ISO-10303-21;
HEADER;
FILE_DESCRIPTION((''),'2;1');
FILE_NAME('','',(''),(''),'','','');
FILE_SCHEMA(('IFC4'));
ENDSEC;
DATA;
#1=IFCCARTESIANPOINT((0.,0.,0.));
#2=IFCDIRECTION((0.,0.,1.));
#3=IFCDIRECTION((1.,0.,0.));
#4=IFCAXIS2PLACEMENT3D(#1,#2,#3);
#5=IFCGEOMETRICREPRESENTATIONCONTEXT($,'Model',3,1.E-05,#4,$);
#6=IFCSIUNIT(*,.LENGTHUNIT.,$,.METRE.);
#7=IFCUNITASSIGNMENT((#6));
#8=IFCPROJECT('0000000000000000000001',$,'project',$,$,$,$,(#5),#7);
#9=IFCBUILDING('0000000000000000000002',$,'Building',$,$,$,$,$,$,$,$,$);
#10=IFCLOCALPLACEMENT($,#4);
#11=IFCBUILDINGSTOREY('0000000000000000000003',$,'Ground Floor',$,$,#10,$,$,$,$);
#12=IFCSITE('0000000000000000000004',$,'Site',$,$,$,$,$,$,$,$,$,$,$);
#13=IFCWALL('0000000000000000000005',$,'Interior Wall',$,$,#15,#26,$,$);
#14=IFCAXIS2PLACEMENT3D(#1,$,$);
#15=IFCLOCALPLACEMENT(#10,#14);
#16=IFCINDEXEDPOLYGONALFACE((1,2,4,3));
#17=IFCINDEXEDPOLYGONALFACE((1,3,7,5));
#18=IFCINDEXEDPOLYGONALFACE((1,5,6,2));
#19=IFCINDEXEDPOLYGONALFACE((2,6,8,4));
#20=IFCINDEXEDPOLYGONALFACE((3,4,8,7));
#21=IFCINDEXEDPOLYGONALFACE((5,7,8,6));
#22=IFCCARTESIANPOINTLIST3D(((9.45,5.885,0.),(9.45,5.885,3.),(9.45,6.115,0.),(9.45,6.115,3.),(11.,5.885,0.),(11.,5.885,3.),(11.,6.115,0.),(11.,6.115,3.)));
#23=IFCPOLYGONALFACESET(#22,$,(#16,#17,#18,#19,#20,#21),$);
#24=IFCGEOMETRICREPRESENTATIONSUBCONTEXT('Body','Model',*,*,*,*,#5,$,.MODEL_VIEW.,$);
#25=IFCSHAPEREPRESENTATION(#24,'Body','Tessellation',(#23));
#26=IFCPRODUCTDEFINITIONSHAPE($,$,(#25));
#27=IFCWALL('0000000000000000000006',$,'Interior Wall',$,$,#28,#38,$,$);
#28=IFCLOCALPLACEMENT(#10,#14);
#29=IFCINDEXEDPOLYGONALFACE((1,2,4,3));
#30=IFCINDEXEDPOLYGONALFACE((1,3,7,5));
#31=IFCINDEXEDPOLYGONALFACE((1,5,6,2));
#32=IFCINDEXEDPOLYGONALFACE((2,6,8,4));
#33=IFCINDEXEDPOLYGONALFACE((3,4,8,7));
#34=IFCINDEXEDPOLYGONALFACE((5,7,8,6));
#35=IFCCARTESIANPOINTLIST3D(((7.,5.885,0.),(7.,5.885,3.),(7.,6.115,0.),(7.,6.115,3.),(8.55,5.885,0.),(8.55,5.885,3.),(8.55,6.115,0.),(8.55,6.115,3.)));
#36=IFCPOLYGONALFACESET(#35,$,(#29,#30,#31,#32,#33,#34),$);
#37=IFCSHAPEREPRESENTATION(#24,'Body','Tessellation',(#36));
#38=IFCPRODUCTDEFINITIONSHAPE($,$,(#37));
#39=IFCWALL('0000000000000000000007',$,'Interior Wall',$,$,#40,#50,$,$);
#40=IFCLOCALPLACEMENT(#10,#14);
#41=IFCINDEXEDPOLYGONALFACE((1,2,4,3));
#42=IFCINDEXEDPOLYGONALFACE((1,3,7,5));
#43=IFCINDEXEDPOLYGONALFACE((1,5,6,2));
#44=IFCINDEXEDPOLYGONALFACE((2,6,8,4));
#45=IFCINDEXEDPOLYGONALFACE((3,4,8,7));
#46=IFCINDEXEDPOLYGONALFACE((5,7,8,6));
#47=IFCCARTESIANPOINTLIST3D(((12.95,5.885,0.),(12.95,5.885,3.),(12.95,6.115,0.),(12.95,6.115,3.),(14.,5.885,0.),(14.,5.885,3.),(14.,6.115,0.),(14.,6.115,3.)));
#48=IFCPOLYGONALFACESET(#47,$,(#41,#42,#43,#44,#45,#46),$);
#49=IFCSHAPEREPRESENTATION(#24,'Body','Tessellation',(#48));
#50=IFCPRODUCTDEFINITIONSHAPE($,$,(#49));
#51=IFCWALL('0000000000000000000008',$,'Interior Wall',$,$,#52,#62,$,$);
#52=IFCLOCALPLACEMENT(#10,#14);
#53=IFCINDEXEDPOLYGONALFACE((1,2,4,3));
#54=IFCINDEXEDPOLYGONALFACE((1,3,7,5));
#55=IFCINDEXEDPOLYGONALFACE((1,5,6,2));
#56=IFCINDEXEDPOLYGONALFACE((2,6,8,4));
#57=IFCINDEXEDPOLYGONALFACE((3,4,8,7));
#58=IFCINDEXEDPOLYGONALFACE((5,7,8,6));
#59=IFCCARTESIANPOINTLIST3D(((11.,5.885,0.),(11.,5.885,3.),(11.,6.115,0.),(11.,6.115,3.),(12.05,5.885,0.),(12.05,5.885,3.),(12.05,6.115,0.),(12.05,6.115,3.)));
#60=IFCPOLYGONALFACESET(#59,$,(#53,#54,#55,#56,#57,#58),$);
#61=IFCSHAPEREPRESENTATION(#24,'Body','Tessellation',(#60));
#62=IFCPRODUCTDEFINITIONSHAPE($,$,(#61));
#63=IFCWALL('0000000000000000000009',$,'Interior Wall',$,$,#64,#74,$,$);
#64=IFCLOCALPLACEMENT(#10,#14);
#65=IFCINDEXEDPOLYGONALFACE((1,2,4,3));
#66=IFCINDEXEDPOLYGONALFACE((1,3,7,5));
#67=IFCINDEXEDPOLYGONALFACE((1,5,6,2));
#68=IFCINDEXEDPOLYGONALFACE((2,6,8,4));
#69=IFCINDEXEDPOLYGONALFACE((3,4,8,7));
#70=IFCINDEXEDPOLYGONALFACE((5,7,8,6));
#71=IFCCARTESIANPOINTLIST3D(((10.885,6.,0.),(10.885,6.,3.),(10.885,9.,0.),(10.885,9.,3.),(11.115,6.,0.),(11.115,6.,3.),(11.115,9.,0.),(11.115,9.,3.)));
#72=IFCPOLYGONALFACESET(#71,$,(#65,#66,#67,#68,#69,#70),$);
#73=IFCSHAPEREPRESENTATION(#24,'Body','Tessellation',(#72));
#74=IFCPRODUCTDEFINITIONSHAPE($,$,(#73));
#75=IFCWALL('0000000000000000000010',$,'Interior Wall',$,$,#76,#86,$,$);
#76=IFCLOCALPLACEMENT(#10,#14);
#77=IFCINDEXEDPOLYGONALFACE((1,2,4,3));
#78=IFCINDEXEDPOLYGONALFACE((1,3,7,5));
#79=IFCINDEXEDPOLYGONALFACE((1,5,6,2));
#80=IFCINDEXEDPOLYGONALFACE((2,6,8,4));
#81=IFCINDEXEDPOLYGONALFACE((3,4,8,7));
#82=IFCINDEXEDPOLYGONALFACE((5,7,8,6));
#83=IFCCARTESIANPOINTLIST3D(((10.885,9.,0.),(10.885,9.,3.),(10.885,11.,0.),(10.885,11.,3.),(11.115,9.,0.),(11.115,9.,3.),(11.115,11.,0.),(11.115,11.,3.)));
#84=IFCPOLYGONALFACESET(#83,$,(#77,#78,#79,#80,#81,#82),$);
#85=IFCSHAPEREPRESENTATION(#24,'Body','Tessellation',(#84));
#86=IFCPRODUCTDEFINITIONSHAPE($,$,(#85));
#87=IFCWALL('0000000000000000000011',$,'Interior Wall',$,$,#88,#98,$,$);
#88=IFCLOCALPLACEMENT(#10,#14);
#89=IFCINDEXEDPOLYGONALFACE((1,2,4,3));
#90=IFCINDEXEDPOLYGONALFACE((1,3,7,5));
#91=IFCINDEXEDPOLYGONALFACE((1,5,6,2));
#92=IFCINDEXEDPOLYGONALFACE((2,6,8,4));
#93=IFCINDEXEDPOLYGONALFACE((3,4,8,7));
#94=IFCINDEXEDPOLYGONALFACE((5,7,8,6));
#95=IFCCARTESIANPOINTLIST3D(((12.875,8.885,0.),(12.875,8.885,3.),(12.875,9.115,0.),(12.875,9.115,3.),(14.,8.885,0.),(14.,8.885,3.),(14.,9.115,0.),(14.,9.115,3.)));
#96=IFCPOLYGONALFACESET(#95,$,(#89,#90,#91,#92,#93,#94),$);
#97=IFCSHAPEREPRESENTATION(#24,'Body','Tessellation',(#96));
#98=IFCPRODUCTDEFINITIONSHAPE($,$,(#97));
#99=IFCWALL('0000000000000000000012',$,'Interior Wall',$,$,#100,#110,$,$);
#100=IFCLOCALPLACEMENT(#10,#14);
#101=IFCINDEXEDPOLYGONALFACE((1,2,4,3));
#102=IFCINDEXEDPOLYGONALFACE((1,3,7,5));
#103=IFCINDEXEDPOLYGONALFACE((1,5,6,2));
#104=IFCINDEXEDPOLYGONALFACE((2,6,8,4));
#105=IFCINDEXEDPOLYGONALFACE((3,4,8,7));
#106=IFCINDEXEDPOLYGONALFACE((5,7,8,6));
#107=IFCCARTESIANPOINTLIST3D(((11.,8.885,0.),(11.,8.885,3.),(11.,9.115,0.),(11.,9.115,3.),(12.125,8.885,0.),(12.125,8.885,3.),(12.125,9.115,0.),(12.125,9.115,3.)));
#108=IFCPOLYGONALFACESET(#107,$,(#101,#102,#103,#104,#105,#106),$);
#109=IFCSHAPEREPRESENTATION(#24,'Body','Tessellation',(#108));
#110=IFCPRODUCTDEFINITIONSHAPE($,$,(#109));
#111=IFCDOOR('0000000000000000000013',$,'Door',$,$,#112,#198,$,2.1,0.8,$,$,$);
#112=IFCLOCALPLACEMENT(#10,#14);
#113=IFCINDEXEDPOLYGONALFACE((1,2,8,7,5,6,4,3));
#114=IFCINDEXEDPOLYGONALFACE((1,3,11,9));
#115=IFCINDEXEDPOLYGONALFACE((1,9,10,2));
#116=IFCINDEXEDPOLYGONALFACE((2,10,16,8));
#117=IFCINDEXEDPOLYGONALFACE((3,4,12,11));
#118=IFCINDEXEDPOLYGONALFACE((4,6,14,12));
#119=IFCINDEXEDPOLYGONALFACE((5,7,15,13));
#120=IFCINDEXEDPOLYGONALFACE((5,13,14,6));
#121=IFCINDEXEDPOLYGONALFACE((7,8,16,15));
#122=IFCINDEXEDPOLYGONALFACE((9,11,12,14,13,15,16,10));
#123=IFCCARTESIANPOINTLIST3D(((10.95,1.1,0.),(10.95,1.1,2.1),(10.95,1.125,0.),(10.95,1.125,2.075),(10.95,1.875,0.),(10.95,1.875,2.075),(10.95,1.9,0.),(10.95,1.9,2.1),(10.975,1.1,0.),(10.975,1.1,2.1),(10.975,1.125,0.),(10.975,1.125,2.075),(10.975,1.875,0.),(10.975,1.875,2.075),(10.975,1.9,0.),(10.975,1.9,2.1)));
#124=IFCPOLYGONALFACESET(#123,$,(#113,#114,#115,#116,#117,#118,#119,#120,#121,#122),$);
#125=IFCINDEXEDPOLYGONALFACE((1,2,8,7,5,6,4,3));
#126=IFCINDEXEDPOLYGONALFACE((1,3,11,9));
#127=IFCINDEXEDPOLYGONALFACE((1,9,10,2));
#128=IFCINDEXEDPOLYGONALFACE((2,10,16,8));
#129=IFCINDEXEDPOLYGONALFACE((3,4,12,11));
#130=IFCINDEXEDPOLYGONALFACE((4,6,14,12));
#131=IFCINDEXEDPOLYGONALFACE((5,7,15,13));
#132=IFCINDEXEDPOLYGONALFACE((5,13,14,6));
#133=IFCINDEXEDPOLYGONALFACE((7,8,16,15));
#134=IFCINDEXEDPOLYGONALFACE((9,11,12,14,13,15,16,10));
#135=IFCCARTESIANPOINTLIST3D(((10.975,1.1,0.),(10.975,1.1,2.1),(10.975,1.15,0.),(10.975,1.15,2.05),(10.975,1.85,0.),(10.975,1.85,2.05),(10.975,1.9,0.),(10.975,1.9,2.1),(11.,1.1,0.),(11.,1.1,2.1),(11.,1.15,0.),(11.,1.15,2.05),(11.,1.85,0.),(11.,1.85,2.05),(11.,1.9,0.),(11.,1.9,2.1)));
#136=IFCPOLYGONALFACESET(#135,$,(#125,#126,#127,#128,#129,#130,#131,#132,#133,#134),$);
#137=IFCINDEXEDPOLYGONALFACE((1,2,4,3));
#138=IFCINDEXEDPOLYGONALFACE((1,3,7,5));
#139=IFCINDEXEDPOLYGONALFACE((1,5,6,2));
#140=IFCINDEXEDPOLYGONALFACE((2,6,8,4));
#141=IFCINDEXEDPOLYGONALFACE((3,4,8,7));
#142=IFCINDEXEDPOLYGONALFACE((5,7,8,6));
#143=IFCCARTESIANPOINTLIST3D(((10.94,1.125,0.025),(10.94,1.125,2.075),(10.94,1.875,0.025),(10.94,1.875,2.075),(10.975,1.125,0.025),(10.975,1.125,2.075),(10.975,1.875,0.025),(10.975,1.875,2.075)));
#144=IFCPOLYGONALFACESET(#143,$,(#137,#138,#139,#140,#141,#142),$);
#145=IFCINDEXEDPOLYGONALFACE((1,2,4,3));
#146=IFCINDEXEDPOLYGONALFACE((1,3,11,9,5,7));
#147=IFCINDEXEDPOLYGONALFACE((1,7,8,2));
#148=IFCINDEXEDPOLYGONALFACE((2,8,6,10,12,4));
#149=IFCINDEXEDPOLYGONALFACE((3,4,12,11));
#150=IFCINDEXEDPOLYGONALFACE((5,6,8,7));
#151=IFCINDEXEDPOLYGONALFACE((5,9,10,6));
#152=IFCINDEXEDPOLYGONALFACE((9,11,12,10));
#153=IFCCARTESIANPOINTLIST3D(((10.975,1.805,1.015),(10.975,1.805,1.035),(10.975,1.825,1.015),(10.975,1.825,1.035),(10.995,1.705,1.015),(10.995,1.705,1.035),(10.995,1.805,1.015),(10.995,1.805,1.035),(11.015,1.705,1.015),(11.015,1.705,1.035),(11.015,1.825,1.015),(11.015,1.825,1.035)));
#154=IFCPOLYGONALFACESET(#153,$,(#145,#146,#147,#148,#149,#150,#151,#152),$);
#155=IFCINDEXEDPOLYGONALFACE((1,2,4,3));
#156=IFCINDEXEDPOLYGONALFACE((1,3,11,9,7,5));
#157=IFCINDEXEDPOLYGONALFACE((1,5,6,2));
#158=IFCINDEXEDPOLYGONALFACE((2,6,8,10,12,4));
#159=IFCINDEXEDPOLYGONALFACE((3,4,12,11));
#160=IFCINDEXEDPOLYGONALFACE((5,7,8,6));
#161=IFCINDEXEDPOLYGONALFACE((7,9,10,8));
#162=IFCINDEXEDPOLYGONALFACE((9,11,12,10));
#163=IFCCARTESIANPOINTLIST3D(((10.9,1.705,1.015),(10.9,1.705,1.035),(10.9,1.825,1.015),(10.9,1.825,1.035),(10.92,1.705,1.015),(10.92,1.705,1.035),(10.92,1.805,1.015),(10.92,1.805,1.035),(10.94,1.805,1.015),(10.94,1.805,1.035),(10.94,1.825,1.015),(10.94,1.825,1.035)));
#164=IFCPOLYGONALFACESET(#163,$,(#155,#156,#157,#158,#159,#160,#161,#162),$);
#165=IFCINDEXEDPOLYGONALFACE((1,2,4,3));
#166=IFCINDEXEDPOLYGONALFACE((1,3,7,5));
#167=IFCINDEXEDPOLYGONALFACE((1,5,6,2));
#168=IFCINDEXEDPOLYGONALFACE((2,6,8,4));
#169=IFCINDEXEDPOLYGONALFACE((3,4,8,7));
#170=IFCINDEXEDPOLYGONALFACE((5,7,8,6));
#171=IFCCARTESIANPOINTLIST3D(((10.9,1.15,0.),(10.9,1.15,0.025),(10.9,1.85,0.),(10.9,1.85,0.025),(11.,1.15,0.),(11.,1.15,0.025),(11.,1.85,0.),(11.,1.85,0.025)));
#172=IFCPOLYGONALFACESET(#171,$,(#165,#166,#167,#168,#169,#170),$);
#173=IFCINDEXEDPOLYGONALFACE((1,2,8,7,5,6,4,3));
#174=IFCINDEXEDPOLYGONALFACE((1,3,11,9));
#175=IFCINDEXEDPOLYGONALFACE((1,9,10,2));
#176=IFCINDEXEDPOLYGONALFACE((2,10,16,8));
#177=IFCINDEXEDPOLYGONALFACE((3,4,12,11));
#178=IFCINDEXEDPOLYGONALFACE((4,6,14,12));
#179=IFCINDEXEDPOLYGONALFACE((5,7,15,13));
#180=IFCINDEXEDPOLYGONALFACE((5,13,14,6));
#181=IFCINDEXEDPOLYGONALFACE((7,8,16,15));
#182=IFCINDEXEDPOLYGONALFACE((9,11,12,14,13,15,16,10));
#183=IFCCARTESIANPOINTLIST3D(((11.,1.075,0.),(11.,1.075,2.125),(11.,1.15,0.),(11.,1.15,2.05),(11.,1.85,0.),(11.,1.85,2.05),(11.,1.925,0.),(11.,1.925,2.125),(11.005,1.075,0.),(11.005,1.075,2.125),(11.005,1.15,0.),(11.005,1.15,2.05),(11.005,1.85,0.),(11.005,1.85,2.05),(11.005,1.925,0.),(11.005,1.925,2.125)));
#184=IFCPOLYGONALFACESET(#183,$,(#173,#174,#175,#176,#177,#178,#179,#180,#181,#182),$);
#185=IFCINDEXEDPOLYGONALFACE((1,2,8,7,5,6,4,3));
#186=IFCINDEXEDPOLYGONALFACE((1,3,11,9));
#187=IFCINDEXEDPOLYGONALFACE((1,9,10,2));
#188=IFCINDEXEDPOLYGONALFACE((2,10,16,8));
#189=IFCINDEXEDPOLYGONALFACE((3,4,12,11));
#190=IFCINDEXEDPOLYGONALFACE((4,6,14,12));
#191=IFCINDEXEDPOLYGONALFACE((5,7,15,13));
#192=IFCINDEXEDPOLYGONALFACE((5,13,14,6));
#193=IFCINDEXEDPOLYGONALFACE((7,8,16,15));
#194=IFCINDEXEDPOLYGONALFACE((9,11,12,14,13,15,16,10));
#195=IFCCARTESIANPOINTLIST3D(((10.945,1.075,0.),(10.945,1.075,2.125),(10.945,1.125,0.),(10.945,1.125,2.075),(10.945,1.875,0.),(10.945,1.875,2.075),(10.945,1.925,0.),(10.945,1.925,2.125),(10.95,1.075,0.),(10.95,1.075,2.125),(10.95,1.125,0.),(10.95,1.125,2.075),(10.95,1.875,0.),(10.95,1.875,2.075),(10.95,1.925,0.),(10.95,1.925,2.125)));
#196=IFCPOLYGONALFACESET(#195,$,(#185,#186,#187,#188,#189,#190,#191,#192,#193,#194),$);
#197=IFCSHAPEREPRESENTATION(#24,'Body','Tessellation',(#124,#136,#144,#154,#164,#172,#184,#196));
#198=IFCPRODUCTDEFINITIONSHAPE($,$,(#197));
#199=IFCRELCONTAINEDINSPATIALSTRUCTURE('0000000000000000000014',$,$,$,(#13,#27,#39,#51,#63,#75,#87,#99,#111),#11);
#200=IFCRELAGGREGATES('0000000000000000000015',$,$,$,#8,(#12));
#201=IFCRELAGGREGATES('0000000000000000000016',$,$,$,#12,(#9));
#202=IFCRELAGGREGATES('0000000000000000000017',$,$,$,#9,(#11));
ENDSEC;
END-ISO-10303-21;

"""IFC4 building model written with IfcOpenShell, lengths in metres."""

from ifc_helpers import new_model, si_unit, frame, origin_with_axes, place, context, subcontext, project, spatial, line, indexed_curve, outline, extrude, element, save


model = new_model("IFC4")

# Units and contexts
model_context = context("Model", 3, precision=1e-05, world=origin_with_axes())
body_context = subcontext(model_context, "Body", "Model", "MODEL_VIEW")
ifc_project = project(units=[si_unit("LENGTHUNIT", "METRE")], contexts=[model_context])

# Site, building, storey
site = spatial("IfcSite", under=ifc_project, Name="Site")
building = spatial("IfcBuilding", under=site, Name="Building")
storey_placement = place(None, origin_with_axes())
storey = spatial("IfcBuildingStorey", under=building, at=storey_placement, Name="Ground Floor")

# Walls
for number, where, z_axis, x_axis, name in (
    (1, (11.0, 6.0, 0.0), (0.0, 0.0, 1.0), (-1.0, 0.0, 0.0), "Interior Wall"),
    (2, (8.55, 6.0, 0.0), (0.0, 0.0, 1.0), (-1.0, 0.0, 0.0), "Interior Wall"),
):
    element("IfcWall", number, at=place(storey_placement, frame(where, z_axis=z_axis, x_axis=x_axis)), inside=storey, Name=name, context=body_context, shape_type="SweptSolid", body=[
        extrude(outline(indexed_curve([(0.0, 0.0), (0.0, 0.23), (1.55, 0.23), (1.55, 0.0), (0.0, 0.0)], self_intersect=False)), frame((0.0, -0.115, 0.0), z_axis=(0.0, 0.0, 1.0), x_axis=(1.0, 0.0, 0.0)), (0.0, 0.0, 1.0), 3.0),
    ])
for number, where, z_axis, x_axis, name in (
    (3, (14.0, 6.0, 0.0), (0.0, 0.0, 1.0), (-1.0, 0.0, 0.0), "Interior Wall"),
    (4, (12.05, 6.0, 0.0), (0.0, 0.0, 1.0), (-1.0, 0.0, 0.0), "Interior Wall"),
):
    element("IfcWall", number, at=place(storey_placement, frame(where, z_axis=z_axis, x_axis=x_axis)), inside=storey, Name=name, context=body_context, shape_type="SweptSolid", body=[
        extrude(outline(indexed_curve([(0.0, 0.0), (0.0, 0.23), (1.05, 0.23), (1.05, 0.0), (0.0, 0.0)], self_intersect=False)), frame((0.0, -0.115, 0.0), z_axis=(0.0, 0.0, 1.0), x_axis=(1.0, 0.0, 0.0)), (0.0, 0.0, 1.0), 3.0),
    ])
wall_1_placement = place(storey_placement, frame((11.0, 6.0, 0.0), z_axis=(0.0, 0.0, 1.0), x_axis=(0.0, 1.0, 0.0)))
element("IfcWall", 5, at=wall_1_placement, inside=storey, Name="Interior Wall", context=body_context, shape_type="SweptSolid", body=[
    extrude(outline(indexed_curve([(0.0, 0.0), (0.0, 0.23), (3.0, 0.23), (3.0, 0.0), (0.0, 0.0)], self_intersect=False)), frame((0.0, -0.115, 0.0), z_axis=(0.0, 0.0, 1.0), x_axis=(1.0, 0.0, 0.0)), (0.0, 0.0, 1.0), 3.0),
])
wall_2_placement = place(storey_placement, frame((11.0, 9.0, 0.0), z_axis=(0.0, 0.0, 1.0), x_axis=(0.0, 1.0, 0.0)))
element("IfcWall", 6, at=wall_2_placement, inside=storey, Name="Interior Wall", context=body_context, shape_type="SweptSolid", body=[
    extrude(outline(indexed_curve([(0.0, 0.0), (0.0, 0.23), (2.0, 0.23), (2.0, 0.0), (0.0, 0.0)], self_intersect=False)), frame((0.0, -0.115, 0.0), z_axis=(0.0, 0.0, 1.0), x_axis=(1.0, 0.0, 0.0)), (0.0, 0.0, 1.0), 3.0),
])
for number, where, z_axis, x_axis, name in (
    (7, (14.0, 9.0, 0.0), (0.0, 0.0, 1.0), (-1.0, 0.0, 0.0), "Interior Wall"),
    (8, (12.125, 9.0, 0.0), (0.0, 0.0, 1.0), (-1.0, 0.0, 0.0), "Interior Wall"),
):
    element("IfcWall", number, at=place(storey_placement, frame(where, z_axis=z_axis, x_axis=x_axis)), inside=storey, Name=name, context=body_context, shape_type="SweptSolid", body=[
        extrude(outline(indexed_curve([(0.0, 0.0), (0.0, 0.23), (1.125, 0.23), (1.125, 0.0), (0.0, 0.0)], self_intersect=False)), frame((0.0, -0.115, 0.0), z_axis=(0.0, 0.0, 1.0), x_axis=(1.0, 0.0, 0.0)), (0.0, 0.0, 1.0), 3.0),
    ])

# Door
door_1_placement = place(storey_placement, frame((11.0, 1.1, 0.0), z_axis=(0.0, 0.0, 1.0), x_axis=(0.0, 1.0, 0.0)))
element("IfcDoor", 9, at=door_1_placement, inside=storey, Name="Door", OverallHeight=2.1, OverallWidth=0.8, context=body_context, shape_type="SweptSolid", body=[
    extrude(outline(indexed_curve([(0.0, 0.0), (0.0, 2.1), (0.8, 2.1), (0.8, 0.0), (0.775, 0.0), (0.775, 2.075), (0.025, 2.075), (0.025, 0.0)], segments=[line(1, 2, 3, 4, 5, 6, 7, 8, 1)])), frame((0.0, 0.025, 0.0), z_axis=(0.0, -1.0, 0.0), x_axis=(1.0, 0.0, 0.0)), (0.0, 0.0, -1.0), 0.025),
    extrude(outline(indexed_curve([(0.0, 0.0), (0.0, 2.1), (0.8, 2.1), (0.8, 0.0), (0.75, 0.0), (0.75, 2.05), (0.05, 2.05), (0.05, 0.0)], segments=[line(1, 2, 3, 4, 5, 6, 7, 8, 1)])), frame((0.0, 0.0, 0.0), z_axis=(0.0, -1.0, 0.0), x_axis=(1.0, 0.0, 0.0)), (0.0, 0.0, -1.0), 0.025),
    extrude(outline(indexed_curve([(0.0, 0.0), (0.75, 0.0), (0.75, 0.035), (0.0, 0.035)], segments=[line(1, 2, 3, 4, 1)])), frame((0.025, 0.025, 0.025), z_axis=(0.0, 0.0, 1.0), x_axis=(1.0, 0.0, 0.0)), (0.0, 0.0, 1.0), 2.05),
    extrude(outline(indexed_curve([(0.0, 0.0), (0.0, -0.04), (-0.12, -0.04), (-0.12, -0.02), (-0.02, -0.02), (-0.02, 0.0)], segments=[line(1, 2, 3, 4, 5, 6, 1)])), frame((0.725, 0.025, 1.015), z_axis=(0.0, 0.0, 1.0), x_axis=(1.0, 0.0, 0.0)), (0.0, 0.0, 1.0), 0.02),
    extrude(outline(indexed_curve([(0.0, 0.0), (0.0, 0.04), (-0.12, 0.04), (-0.12, 0.02), (-0.02, 0.02), (-0.02, 0.0)], segments=[line(1, 2, 3, 4, 5, 6, 1)])), frame((0.725, 0.06, 1.015), z_axis=(0.0, 0.0, 1.0), x_axis=(1.0, 0.0, 0.0)), (0.0, 0.0, 1.0), 0.02),
    extrude(outline(indexed_curve([(0.0, 0.0), (0.7, 0.0), (0.7, 0.1), (0.0, 0.1)], segments=[line(1, 2, 3, 4, 1)])), frame((0.05, 0.0, 0.0), z_axis=(0.0, 0.0, 1.0), x_axis=(1.0, 0.0, 0.0)), (0.0, 0.0, 1.0), 0.025),
    extrude(outline(indexed_curve([(0.0, 0.0), (0.0, 2.125), (0.85, 2.125), (0.85, 0.0), (0.775, 0.0), (0.775, 2.05), (0.075, 2.05), (0.075, 0.0)], segments=[line(1, 2, 3, 4, 5, 6, 7, 8, 1)])), frame((-0.025, -0.005, 0.0), z_axis=(0.0, -1.0, 0.0), x_axis=(1.0, 0.0, 0.0)), (0.0, 0.0, -1.0), 0.005),
    extrude(outline(indexed_curve([(0.0, 0.0), (0.0, 2.125), (0.85, 2.125), (0.85, 0.0), (0.8, 0.0), (0.8, 2.075), (0.05, 2.075), (0.05, 0.0)], segments=[line(1, 2, 3, 4, 5, 6, 7, 8, 1)])), frame((-0.025, 0.05, 0.0), z_axis=(0.0, -1.0, 0.0), x_axis=(1.0, 0.0, 0.0)), (0.0, 0.0, -1.0), 0.005),
])

save(model, "model.ifc")
